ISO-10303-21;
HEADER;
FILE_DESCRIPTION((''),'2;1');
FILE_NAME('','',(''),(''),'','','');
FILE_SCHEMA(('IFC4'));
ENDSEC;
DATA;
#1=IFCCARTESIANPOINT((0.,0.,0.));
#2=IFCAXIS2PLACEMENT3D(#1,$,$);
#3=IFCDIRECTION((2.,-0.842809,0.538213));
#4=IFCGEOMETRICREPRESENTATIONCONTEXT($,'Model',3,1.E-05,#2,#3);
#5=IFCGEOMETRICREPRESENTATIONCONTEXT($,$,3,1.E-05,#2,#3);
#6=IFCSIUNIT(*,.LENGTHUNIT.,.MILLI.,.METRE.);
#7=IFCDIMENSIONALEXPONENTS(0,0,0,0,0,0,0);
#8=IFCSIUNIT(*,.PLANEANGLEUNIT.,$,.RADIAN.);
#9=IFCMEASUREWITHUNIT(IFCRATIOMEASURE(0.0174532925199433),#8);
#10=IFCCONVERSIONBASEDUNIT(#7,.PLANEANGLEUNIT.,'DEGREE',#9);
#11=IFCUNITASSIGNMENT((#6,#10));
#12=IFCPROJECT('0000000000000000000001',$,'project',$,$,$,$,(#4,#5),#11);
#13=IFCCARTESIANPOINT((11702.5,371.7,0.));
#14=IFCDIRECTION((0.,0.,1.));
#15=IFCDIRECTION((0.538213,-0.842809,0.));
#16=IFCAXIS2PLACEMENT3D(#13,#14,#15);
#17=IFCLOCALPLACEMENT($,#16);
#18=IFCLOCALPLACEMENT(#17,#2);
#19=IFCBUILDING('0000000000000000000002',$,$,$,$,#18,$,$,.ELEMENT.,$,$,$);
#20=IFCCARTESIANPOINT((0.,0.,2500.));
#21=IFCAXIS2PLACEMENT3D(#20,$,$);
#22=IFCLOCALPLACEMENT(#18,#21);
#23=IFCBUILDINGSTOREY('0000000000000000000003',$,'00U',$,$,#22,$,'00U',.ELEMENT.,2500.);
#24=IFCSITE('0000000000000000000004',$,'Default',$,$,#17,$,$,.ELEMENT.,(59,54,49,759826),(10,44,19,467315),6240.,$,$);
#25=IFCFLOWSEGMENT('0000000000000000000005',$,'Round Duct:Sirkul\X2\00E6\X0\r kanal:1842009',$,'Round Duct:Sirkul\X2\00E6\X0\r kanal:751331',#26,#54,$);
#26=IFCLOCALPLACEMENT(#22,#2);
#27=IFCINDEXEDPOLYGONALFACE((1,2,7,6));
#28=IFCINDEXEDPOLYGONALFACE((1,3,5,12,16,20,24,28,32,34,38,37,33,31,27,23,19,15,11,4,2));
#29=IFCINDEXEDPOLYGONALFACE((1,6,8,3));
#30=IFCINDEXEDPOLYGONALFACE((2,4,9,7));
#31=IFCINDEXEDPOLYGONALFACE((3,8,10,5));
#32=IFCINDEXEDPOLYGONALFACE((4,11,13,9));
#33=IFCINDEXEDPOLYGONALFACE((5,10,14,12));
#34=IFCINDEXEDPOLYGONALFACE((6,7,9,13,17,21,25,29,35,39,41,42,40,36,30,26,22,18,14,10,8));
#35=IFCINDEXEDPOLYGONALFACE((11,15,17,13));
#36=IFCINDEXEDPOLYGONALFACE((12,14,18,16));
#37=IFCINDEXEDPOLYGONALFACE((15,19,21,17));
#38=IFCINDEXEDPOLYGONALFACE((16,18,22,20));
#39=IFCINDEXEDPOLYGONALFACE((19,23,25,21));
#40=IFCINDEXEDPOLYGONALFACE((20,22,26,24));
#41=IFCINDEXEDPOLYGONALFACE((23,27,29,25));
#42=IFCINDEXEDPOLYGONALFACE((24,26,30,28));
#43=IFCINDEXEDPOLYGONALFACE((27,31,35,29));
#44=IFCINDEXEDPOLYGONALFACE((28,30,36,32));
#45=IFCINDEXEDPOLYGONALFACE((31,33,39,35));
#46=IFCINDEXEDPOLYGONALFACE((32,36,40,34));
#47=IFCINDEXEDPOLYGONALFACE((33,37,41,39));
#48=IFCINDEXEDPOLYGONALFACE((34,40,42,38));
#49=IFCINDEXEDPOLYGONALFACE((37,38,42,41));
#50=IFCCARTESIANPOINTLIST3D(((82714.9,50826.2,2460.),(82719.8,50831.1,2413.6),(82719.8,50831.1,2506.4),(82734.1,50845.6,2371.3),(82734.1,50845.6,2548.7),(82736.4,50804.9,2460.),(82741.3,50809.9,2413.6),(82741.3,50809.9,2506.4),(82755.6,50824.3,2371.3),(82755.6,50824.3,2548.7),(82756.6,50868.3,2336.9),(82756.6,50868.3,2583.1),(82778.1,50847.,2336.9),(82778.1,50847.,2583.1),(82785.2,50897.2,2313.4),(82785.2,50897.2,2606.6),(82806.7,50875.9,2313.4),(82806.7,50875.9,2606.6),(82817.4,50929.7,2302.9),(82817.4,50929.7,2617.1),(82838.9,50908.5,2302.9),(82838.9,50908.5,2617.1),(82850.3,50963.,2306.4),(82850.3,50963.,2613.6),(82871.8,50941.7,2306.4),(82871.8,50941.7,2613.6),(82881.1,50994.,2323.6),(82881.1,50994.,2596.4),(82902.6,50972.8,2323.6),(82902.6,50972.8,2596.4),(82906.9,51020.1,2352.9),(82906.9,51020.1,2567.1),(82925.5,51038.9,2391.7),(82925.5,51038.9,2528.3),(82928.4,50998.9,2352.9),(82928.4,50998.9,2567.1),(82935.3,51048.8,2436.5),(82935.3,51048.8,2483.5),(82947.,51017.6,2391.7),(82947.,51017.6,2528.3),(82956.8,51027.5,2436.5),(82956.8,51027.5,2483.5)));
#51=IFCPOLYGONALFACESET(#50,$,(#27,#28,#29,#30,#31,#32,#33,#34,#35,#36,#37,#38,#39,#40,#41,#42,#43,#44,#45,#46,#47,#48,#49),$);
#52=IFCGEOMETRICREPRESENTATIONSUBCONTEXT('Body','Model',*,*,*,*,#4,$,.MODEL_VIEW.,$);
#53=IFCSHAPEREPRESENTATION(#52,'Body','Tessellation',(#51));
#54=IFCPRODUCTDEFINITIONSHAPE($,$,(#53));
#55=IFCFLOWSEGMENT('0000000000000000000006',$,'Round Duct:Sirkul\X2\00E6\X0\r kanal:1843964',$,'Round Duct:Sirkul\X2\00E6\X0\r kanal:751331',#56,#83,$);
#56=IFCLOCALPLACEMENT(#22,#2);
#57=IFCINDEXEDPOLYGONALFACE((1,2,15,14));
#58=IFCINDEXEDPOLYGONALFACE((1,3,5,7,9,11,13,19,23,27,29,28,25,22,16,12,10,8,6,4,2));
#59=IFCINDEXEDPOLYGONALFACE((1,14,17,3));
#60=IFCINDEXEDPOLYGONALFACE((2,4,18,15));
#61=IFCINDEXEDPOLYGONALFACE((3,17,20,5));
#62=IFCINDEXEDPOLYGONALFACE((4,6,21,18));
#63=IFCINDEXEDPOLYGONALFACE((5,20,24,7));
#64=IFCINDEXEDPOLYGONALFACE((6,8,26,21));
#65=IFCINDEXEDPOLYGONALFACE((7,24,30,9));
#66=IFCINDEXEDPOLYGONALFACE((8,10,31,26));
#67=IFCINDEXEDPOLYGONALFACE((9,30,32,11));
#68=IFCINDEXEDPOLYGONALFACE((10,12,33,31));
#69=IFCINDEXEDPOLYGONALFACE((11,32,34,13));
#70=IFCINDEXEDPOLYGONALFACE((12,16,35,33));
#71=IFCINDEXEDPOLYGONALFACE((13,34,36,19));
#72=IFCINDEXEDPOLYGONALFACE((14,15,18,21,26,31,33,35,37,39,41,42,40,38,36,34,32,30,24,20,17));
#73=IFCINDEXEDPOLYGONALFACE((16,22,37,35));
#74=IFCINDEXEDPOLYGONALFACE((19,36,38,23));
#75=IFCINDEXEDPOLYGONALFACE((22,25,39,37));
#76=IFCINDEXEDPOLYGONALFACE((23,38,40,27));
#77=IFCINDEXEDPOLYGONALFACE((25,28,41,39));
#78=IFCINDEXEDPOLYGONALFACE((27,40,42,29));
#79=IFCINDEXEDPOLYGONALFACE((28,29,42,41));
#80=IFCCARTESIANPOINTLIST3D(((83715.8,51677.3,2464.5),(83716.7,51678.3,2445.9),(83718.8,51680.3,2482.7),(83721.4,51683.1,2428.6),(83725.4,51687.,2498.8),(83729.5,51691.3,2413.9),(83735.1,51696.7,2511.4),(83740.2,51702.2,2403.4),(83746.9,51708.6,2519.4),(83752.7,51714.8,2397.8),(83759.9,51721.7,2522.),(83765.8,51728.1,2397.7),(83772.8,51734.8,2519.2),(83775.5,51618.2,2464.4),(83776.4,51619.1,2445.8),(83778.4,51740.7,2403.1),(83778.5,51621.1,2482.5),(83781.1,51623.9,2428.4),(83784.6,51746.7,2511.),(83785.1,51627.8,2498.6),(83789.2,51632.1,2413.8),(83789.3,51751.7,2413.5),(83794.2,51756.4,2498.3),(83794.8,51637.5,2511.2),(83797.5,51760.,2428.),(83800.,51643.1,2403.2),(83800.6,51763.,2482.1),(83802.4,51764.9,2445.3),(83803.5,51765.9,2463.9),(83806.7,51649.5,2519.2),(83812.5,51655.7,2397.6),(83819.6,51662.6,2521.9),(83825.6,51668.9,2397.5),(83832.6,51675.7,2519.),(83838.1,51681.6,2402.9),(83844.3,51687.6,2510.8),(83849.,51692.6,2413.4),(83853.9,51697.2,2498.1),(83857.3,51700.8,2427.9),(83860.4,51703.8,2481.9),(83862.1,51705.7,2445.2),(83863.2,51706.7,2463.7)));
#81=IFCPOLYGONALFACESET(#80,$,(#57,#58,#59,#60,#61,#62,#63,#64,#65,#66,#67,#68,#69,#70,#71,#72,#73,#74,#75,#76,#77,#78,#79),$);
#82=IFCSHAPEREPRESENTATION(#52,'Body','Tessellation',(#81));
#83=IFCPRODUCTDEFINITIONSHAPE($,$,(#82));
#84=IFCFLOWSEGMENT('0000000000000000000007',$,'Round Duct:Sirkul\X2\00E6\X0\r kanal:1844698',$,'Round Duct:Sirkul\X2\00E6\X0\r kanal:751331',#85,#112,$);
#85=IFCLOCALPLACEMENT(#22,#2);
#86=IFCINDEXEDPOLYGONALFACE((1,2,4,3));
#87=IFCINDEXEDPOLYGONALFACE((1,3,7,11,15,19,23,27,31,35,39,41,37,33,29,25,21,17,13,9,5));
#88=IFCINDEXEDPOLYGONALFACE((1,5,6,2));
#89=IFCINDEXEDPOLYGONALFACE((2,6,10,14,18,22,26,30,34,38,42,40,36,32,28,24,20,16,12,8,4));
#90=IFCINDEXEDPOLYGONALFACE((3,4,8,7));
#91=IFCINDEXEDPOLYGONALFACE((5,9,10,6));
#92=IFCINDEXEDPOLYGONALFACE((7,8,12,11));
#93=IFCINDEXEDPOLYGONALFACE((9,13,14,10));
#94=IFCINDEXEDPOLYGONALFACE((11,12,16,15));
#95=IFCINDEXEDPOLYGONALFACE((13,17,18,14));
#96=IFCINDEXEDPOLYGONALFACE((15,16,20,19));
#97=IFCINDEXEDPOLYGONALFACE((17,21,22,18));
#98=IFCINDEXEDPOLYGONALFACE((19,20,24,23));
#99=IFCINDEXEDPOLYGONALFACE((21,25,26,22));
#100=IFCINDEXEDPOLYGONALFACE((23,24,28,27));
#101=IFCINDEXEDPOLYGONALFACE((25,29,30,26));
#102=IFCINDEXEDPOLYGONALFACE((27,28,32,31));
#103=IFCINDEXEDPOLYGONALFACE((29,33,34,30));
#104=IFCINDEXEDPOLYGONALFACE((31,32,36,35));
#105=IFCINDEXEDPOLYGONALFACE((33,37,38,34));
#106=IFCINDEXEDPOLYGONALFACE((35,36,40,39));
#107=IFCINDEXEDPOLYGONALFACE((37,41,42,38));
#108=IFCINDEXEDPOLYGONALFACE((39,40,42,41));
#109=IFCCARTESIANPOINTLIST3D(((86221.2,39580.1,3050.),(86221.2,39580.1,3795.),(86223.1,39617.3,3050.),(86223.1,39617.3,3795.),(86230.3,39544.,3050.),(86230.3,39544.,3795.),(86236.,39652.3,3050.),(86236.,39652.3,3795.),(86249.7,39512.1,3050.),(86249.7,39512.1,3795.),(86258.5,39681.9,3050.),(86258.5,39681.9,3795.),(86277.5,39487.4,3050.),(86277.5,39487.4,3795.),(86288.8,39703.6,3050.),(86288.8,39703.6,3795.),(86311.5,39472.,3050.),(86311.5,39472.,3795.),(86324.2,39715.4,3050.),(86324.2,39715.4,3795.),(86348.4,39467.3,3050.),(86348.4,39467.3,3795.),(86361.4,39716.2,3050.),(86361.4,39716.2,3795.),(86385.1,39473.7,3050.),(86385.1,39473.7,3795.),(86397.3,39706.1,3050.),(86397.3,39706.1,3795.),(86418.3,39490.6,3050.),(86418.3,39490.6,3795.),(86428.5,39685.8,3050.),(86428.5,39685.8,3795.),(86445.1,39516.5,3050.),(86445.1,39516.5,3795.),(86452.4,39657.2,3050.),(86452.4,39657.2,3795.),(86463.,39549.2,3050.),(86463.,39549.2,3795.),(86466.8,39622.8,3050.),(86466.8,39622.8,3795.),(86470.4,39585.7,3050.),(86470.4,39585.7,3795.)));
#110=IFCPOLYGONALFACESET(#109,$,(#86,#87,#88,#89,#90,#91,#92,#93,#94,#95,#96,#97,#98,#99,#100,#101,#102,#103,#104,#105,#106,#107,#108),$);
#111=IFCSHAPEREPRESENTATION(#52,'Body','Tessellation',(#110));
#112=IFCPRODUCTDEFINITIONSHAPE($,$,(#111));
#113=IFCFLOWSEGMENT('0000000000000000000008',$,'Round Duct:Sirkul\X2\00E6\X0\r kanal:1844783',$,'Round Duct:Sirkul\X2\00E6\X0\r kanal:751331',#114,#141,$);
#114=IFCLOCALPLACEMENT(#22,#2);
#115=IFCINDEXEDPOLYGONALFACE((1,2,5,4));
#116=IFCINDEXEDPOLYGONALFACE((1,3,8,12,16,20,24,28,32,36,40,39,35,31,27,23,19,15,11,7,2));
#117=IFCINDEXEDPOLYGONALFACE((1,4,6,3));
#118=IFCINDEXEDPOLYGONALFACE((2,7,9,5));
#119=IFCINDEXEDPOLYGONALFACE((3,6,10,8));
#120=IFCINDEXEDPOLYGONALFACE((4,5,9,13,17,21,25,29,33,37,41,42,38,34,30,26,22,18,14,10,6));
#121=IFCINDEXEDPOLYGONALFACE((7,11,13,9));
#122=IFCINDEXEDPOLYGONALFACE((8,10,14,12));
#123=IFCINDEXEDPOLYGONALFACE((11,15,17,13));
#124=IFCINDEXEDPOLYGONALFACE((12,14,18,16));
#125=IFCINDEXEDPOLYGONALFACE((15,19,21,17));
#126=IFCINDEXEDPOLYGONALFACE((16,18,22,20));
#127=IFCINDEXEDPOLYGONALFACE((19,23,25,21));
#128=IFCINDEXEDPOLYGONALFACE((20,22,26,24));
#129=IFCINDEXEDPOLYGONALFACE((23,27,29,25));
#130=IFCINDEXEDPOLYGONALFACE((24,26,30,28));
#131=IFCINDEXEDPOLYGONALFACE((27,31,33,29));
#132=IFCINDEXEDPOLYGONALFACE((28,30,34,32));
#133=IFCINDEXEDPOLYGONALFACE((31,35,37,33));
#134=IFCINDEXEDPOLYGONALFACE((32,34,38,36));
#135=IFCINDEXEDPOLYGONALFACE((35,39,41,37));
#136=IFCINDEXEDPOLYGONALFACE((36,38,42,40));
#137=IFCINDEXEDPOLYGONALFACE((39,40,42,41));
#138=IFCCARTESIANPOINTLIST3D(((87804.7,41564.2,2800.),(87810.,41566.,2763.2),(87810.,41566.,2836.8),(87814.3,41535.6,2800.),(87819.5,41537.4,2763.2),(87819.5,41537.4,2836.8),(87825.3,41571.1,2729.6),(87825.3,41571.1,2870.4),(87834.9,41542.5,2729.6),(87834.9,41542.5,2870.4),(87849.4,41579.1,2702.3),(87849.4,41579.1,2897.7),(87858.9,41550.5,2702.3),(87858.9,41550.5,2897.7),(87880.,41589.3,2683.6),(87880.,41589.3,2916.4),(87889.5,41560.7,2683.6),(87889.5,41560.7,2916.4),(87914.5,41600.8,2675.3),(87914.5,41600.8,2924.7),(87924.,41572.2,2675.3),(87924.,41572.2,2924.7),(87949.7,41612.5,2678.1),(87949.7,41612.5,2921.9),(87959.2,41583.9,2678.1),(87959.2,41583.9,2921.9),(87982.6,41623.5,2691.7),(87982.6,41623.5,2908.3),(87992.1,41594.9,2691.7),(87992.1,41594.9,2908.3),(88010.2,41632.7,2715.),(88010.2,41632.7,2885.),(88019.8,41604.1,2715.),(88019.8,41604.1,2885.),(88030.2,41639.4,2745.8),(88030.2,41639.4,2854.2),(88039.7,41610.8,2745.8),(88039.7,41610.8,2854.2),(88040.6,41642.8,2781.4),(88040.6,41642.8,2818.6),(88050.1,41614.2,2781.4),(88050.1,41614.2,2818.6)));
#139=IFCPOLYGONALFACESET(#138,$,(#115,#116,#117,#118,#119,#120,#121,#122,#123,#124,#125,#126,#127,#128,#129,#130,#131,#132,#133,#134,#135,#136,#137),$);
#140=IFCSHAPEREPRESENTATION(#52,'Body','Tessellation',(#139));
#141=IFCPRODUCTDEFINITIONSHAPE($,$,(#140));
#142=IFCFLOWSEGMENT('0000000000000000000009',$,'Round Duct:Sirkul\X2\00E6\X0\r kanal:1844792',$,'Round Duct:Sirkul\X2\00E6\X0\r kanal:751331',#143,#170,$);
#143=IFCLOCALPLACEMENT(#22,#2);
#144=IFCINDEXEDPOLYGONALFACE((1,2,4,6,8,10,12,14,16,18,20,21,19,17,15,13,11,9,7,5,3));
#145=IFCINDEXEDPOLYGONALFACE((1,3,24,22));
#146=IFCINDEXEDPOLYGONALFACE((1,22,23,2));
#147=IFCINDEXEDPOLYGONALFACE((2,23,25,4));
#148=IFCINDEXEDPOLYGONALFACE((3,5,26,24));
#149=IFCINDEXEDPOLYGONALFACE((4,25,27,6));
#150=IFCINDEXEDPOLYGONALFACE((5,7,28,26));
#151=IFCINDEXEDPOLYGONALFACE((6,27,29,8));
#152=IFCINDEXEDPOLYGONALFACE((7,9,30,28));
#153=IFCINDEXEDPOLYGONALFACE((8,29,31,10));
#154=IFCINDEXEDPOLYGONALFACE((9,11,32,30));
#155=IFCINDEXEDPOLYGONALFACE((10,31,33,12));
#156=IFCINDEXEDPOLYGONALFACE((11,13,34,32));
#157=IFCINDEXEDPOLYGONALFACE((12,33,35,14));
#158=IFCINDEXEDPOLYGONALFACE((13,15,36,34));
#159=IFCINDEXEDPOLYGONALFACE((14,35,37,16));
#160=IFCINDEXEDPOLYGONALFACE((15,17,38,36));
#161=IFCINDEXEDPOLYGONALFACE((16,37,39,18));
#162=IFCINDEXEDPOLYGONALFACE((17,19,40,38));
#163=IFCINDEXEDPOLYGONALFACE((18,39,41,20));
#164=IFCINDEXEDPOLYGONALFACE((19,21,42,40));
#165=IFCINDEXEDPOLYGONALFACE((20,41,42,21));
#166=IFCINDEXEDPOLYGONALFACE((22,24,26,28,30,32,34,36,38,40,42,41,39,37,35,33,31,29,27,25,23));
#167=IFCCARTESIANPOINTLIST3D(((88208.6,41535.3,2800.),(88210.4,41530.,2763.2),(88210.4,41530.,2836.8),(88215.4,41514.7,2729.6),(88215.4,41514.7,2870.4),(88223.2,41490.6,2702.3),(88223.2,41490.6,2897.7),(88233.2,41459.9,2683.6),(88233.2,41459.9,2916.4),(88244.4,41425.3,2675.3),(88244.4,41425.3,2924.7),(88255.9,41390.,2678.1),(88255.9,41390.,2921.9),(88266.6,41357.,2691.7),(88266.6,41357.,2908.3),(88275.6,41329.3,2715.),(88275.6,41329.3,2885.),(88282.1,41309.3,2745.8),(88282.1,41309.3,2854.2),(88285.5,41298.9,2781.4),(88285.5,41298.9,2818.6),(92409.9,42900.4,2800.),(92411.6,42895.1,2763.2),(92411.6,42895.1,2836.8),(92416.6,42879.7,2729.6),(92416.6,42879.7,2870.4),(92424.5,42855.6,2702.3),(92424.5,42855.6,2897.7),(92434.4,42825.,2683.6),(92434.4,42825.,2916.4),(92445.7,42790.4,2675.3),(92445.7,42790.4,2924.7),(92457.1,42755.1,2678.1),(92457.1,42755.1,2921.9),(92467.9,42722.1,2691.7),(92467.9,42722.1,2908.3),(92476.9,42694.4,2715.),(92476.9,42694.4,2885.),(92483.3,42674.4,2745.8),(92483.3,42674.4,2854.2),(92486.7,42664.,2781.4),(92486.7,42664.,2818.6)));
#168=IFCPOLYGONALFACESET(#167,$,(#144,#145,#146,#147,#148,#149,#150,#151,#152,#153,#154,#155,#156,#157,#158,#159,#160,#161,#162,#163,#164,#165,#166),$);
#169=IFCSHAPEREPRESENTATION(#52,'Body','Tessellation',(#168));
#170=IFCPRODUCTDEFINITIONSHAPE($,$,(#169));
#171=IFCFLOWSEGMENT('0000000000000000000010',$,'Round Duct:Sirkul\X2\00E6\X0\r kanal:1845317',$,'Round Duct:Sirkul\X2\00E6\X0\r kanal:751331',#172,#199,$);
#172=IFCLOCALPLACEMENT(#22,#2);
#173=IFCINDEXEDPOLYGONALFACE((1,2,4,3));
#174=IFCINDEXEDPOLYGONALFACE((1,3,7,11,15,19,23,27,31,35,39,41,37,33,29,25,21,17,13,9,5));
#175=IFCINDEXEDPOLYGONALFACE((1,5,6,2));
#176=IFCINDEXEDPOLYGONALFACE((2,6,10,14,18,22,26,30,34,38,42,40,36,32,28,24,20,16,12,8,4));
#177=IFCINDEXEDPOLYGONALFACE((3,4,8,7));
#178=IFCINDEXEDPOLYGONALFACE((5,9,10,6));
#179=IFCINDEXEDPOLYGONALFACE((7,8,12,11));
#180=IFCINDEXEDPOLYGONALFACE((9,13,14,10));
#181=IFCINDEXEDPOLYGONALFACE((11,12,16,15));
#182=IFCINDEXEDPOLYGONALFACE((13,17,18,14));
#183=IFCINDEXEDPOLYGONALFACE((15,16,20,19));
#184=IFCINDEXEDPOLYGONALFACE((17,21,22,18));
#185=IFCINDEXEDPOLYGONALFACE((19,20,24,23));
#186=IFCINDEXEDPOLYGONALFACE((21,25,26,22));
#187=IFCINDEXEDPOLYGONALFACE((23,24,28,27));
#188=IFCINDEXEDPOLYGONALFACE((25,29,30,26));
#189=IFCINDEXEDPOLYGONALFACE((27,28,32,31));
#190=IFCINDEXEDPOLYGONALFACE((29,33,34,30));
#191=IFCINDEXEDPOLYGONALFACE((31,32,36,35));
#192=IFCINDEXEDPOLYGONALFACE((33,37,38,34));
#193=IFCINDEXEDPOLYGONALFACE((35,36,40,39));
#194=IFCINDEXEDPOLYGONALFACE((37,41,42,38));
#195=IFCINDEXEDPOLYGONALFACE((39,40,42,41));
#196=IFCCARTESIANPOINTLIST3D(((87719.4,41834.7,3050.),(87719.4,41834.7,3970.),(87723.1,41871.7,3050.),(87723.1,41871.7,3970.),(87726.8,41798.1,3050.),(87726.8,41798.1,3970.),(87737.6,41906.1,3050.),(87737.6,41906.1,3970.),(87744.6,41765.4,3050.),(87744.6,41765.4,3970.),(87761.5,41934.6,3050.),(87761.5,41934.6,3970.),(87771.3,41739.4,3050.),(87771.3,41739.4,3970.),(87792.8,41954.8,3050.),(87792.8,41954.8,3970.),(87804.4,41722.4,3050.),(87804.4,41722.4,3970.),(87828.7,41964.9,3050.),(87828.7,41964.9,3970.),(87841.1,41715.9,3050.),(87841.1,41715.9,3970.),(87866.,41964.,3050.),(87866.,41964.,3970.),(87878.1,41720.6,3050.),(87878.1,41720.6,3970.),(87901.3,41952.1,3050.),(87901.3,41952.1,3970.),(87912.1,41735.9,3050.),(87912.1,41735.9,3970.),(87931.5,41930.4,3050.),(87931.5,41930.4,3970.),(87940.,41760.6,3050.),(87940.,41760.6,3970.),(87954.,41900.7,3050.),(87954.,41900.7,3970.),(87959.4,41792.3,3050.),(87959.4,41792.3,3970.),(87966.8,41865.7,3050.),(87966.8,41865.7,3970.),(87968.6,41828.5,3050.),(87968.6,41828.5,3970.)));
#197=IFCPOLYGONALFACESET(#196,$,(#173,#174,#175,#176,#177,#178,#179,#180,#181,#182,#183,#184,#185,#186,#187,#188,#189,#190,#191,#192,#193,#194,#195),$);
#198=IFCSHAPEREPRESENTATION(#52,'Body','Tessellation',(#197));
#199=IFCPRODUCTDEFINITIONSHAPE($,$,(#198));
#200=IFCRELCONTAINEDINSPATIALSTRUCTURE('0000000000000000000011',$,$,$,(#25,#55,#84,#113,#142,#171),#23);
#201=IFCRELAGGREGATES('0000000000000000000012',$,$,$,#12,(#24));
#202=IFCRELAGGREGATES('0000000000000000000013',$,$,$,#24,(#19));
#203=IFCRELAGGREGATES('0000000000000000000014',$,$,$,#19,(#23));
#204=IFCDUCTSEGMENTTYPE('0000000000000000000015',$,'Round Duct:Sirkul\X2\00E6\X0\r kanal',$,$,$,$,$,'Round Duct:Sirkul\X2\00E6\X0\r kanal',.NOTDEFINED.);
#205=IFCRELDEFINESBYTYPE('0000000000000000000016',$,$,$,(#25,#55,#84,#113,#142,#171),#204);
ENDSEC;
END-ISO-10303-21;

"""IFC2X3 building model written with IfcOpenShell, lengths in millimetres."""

from ifc_helpers import new_model, entity, si_unit, converted_unit, direction, frame, frame_2d, origin, origin_2d_with_axis, place, context, subcontext, project, spatial, circle, extrude, type_object, element, save


model = new_model("IFC2X3")

# Units and contexts
model_context = context("Model", 3, precision=1e-05, world=origin(), true_north=direction((2.0, -0.842809, 0.538213)))
context_of_model = context(None, 3, precision=1e-05, world=origin(), true_north=direction((2.0, -0.842809, 0.538213)))
body_context = subcontext(model_context, "Body", "Model", "MODEL_VIEW")
ifc_project = project(units=[si_unit("LENGTHUNIT", "METRE", prefix="MILLI"), converted_unit("PLANEANGLEUNIT", "DEGREE", entity("IfcRatioMeasure", 0.0174532925199433), si_unit("PLANEANGLEUNIT", "RADIAN"), dimensions=[0, 0, 0, 0, 0, 0, 0])], contexts=[model_context, context_of_model])

# Site, building, storey
site_placement = place(None, frame((11702.5, 371.7, 0.0), z_axis=(0.0, 0.0, 1.0), x_axis=(0.538213, -0.842809, 0.0)))
site = spatial("IfcSite", under=ifc_project, at=site_placement, Name="Default", CompositionType="ELEMENT", RefLatitude=(59, 54, 49, 759826), RefLongitude=(10, 44, 19, 467315), RefElevation=6240.0)
building_placement = place(site_placement, origin())
building = spatial("IfcBuilding", under=site, at=building_placement, CompositionType="ELEMENT")
storey_placement = place(building_placement, frame((0.0, 0.0, 2500.0)))
storey = spatial("IfcBuildingStorey", under=building, at=storey_placement, Name="00U", LongName="00U", CompositionType="ELEMENT", Elevation=2500.0)

# Flow segments
duct_segment_type = type_object("IfcDuctSegmentType", Name="Round Duct:Sirkulær kanal", ElementType="Round Duct:Sirkulær kanal", PredefinedType="NOTDEFINED")
flow_segment_1_placement = place(storey_placement, origin())
element("IfcFlowSegment", 1, at=flow_segment_1_placement, inside=storey, type_object=duct_segment_type, Name="Round Duct:Sirkulær kanal:1842009", ObjectType="Round Duct:Sirkulær kanal:751331", context=body_context, shape_type="SweptSolid", body=[
    extrude(circle(Radius=157.5, at=origin_2d_with_axis()), frame((82847.2, 50916.8, 2460.0), z_axis=(-0.710573, 0.703624, 0.0), x_axis=(-0.703624, -0.710573, 0.0)), (0.0, 0.0, 1.0), 30.2),
])
flow_segment_2_placement = place(storey_placement, origin())
element("IfcFlowSegment", 2, at=flow_segment_2_placement, inside=storey, type_object=duct_segment_type, Name="Round Duct:Sirkulær kanal:1843964", ObjectType="Round Duct:Sirkulær kanal:751331", context=body_context, shape_type="SweptSolid", body=[
    extrude(circle(Radius=62.5, at=origin_2d_with_axis()), frame((83759.6, 51721.6, 2459.5), z_axis=(0.710533, -0.703661, -0.002037), x_axis=(0.004886, 0.002039, 0.999986)), (0.0, 0.0, 1.0), 84.1),
])
flow_segment_3_placement = place(storey_placement, origin())
element("IfcFlowSegment", 3, at=flow_segment_3_placement, inside=storey, type_object=duct_segment_type, Name="Round Duct:Sirkulær kanal:1844698", ObjectType="Round Duct:Sirkulær kanal:751331", context=body_context, shape_type="SweptSolid", body=[
    extrude(circle(Radius=125.0, at=frame_2d((0.0, 0.0), x_axis=(1.0, 0.0))), frame((86345.6, 39592.2, 3050.0), z_axis=(0.0, 0.000001, 1.0), x_axis=(0.316277, -0.948667, 0.000001)), (0.0, 0.0, 1.0), 745.0),
])
flow_segment_4_placement = place(storey_placement, origin())
element("IfcFlowSegment", 4, at=flow_segment_4_placement, inside=storey, type_object=duct_segment_type, Name="Round Duct:Sirkulær kanal:1844783", ObjectType="Round Duct:Sirkulær kanal:751331", context=body_context, shape_type="SweptSolid", body=[
    extrude(circle(Radius=125.0, at=origin_2d_with_axis()), frame((87932.9, 41575.1, 2800.0), z_axis=(-0.316277, 0.948667, 0.0), x_axis=(-0.948667, -0.316277, 0.0)), (0.0, 0.0, 1.0), 30.1),
])
flow_segment_5_placement = place(storey_placement, origin())
element("IfcFlowSegment", 5, at=flow_segment_5_placement, inside=storey, type_object=duct_segment_type, Name="Round Duct:Sirkulær kanal:1844792", ObjectType="Round Duct:Sirkulær kanal:751331", context=body_context, shape_type="SweptSolid", body=[
    extrude(circle(Radius=125.0, at=origin_2d_with_axis()), frame((88247.3, 41416.4, 2800.0), z_axis=(0.951057, 0.309017, 0.0), x_axis=(-0.309017, 0.951057, 0.0)), (0.0, 0.0, 1.0), 4417.5),
])
flow_segment_6_placement = place(storey_placement, origin())
element("IfcFlowSegment", 6, at=flow_segment_6_placement, inside=storey, type_object=duct_segment_type, Name="Round Duct:Sirkulær kanal:1845317", ObjectType="Round Duct:Sirkulær kanal:751331", context=body_context, shape_type="SweptSolid", body=[
    extrude(circle(Radius=125.0, at=origin_2d_with_axis()), frame((87844.2, 41840.9, 3050.0), z_axis=(0.000001, 0.0, 1.0), x_axis=(-0.939693, -0.34202, 0.000001)), (0.0, 0.0, 1.0), 920.0),
])

save(model, "model.ifc")
